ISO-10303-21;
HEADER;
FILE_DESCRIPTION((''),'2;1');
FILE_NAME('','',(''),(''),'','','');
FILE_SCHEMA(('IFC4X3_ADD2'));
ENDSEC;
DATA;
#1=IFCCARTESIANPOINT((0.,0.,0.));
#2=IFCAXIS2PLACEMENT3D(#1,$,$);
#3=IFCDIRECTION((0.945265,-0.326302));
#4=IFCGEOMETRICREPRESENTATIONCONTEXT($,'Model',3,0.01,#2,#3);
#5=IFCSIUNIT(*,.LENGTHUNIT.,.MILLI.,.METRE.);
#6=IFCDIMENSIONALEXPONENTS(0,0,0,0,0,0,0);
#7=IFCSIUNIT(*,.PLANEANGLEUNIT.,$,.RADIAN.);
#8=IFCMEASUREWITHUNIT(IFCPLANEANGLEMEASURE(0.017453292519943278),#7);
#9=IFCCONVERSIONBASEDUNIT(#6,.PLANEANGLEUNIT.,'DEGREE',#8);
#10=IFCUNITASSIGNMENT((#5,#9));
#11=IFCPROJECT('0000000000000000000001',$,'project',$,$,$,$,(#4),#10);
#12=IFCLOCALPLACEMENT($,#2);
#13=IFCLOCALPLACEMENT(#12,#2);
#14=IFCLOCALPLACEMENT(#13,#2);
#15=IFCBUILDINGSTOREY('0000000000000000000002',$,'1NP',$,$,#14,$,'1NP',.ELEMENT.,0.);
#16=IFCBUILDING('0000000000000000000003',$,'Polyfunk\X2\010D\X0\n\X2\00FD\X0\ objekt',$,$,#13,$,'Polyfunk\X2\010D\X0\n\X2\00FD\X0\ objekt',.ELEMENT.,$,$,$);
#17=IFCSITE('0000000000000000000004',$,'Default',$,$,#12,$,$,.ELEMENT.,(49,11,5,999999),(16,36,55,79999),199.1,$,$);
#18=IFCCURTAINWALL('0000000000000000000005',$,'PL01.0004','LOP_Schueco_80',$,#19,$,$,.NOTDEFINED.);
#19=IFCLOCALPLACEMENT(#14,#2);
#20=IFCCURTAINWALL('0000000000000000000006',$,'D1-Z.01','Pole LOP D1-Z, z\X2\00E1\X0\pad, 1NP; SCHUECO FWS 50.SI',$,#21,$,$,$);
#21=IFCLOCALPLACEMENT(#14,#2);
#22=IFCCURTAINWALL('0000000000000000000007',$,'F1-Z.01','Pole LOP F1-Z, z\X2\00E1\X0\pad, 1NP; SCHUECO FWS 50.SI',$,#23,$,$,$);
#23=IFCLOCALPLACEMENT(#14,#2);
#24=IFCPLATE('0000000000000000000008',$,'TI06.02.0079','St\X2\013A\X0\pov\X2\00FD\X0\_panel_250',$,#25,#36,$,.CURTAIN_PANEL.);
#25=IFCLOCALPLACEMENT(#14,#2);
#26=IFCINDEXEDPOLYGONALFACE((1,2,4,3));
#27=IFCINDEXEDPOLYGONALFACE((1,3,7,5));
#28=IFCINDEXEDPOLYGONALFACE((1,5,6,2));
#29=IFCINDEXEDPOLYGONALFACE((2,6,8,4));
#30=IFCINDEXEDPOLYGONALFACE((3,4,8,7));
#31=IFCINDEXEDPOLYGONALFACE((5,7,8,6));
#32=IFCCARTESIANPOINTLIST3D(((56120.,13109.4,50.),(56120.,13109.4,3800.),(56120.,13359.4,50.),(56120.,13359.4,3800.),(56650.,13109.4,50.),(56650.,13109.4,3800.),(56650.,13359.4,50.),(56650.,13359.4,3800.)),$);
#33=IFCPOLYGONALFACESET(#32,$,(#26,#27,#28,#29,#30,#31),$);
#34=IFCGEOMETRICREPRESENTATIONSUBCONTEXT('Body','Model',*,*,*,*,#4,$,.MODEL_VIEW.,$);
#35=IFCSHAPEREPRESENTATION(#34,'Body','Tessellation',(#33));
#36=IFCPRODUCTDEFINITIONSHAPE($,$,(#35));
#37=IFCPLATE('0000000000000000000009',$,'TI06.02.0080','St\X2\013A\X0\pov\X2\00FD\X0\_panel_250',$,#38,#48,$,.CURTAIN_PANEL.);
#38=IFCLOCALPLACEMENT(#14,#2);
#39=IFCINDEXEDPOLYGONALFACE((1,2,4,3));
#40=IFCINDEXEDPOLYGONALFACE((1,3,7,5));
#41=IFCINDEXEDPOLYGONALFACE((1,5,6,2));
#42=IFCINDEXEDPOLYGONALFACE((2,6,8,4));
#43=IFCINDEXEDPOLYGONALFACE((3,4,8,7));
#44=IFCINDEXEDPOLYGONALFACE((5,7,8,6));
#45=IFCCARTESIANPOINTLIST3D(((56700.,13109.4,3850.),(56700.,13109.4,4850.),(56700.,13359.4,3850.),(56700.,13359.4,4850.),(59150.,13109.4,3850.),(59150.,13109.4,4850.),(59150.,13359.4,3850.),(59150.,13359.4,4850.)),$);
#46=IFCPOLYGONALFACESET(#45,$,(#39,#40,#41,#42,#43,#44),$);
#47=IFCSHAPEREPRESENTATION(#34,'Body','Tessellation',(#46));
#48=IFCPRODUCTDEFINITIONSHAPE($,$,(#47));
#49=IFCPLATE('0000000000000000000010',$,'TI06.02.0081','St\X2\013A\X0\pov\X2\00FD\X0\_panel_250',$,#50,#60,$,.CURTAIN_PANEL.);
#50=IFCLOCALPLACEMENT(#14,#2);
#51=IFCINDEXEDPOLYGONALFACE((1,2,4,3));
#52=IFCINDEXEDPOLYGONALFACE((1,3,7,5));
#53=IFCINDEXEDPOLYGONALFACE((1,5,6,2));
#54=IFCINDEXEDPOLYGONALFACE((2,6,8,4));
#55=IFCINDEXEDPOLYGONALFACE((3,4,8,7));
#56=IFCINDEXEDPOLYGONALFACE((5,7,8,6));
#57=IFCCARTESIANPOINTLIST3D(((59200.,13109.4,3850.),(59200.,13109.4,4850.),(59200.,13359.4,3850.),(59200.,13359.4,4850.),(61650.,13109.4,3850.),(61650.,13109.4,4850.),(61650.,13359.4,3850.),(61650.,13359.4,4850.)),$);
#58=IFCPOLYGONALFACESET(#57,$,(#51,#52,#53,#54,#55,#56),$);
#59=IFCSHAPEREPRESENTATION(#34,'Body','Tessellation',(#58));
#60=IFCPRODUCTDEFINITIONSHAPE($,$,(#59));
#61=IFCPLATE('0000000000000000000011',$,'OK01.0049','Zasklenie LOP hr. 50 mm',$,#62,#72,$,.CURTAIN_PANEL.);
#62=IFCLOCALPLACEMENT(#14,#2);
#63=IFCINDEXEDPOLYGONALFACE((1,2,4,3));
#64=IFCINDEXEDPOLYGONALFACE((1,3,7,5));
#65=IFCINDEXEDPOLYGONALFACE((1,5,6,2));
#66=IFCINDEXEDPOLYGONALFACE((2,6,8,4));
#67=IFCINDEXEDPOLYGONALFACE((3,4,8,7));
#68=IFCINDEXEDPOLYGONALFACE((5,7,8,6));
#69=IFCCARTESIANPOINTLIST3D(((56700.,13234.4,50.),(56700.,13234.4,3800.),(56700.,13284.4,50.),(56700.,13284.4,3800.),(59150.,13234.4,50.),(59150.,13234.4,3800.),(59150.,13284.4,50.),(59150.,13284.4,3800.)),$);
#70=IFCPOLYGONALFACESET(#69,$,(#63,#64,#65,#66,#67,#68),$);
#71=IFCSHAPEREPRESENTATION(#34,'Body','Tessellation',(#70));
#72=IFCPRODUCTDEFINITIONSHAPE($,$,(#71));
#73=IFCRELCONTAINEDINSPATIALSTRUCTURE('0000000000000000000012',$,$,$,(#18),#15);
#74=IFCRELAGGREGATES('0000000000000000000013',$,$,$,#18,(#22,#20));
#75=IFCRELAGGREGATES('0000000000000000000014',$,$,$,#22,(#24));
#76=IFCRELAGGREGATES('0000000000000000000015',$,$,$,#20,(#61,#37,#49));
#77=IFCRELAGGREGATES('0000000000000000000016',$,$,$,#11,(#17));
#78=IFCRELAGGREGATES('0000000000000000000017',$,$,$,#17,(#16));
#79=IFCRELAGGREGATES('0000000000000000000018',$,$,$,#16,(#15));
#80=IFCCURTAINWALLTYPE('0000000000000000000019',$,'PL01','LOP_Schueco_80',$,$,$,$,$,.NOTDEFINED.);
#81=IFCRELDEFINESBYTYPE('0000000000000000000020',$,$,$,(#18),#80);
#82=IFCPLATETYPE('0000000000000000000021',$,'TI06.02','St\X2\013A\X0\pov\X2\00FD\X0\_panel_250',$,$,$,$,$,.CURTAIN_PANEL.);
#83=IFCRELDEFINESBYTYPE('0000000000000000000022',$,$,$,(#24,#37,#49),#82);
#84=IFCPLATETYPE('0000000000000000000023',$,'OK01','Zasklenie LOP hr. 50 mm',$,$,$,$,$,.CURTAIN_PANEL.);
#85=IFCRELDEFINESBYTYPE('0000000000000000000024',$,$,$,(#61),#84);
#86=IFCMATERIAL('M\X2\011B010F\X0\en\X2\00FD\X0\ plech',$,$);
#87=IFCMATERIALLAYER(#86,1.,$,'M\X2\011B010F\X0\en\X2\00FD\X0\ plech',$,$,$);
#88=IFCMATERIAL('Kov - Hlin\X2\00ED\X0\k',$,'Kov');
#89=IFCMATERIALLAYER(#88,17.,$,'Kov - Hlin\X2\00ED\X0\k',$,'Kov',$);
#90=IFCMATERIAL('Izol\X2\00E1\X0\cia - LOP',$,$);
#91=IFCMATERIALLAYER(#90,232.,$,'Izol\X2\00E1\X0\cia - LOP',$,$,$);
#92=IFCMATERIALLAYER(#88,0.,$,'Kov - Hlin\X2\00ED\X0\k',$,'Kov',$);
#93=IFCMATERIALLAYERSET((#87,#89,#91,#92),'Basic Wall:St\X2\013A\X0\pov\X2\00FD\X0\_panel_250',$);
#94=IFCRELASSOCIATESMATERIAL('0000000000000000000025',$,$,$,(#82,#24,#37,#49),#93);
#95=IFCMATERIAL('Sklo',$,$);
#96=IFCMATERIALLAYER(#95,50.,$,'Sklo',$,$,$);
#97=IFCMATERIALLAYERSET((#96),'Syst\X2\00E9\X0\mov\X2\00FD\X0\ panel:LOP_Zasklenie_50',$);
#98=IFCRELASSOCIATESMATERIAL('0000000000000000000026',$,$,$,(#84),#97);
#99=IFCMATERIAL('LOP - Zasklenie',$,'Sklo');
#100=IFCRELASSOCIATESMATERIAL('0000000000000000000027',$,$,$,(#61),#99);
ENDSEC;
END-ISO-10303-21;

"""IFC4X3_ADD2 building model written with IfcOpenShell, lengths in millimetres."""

from ifc_helpers import new_model, entity, si_unit, converted_unit, direction, frame, frame_2d, origin, place, context, subcontext, project, spatial, rectangle, extrude, source, transform, mapped, material, layer, layer_set, layer_usage, type_object, type_shapes, element, aggregate, save


model = new_model("IFC4X3_ADD2")

# Units and contexts
model_context = context("Model", 3, precision=0.01, world=origin(), true_north=direction((0.945265, -0.326302)))
body_context = subcontext(model_context, "Body", "Model", "MODEL_VIEW")
ifc_project = project(units=[si_unit("LENGTHUNIT", "METRE", prefix="MILLI"), converted_unit("PLANEANGLEUNIT", "DEGREE", entity("IfcPlaneAngleMeasure", 0.017453292519943278), si_unit("PLANEANGLEUNIT", "RADIAN"), dimensions=[0, 0, 0, 0, 0, 0, 0])], contexts=[model_context])

# Site, building, storey
site_placement = place(None, origin())
site = spatial("IfcSite", under=ifc_project, at=site_placement, Name="Default", CompositionType="ELEMENT", RefLatitude=(49, 11, 5, 999999), RefLongitude=(16, 36, 55, 79999), RefElevation=199.1)
building_placement = place(site_placement, origin())
building = spatial("IfcBuilding", under=site, at=building_placement, Name="Polyfunkčný objekt", LongName="Polyfunkčný objekt", CompositionType="ELEMENT")
storey_placement = place(building_placement, origin())
storey = spatial("IfcBuildingStorey", under=building, at=storey_placement, Name="1NP", LongName="1NP", CompositionType="ELEMENT", Elevation=0.0)

# Curtain walls, plates
curtain_wall_type = type_object("IfcCurtainWallType", Name="PL01", Description="LOP_Schueco_80", PredefinedType="NOTDEFINED")
curtain_wall_1_placement = place(storey_placement, origin())
curtain_wall_1 = element("IfcCurtainWall", 1, at=curtain_wall_1_placement, inside=storey, type_object=curtain_wall_type, Name="PL01.0004", Description="LOP_Schueco_80", PredefinedType="NOTDEFINED")
curtain_wall_2 = element("IfcCurtainWall", 2, Name="D1-Z.01", Description="Pole LOP D1-Z, západ, 1NP; SCHUECO FWS 50.SI")
curtain_wall_3 = element("IfcCurtainWall", 3, Name="F1-Z.01", Description="Pole LOP F1-Z, západ, 1NP; SCHUECO FWS 50.SI")
aggregate(curtain_wall_1, [curtain_wall_3, curtain_wall_2])
ifc_material_1 = material(Name="Měďený plech")
ifc_layer_1 = layer(ifc_material_1, 1.0, Name="Měďený plech")
ifc_material_2 = material(Name="Kov - Hliník", Category="Kov")
ifc_layer_2 = layer(ifc_material_2, 17.0, Name="Kov - Hliník", Category="Kov")
ifc_material_3 = material(Name="Izolácia - LOP")
ifc_layer_3 = layer(ifc_material_3, 232.0, Name="Izolácia - LOP")
ifc_layer_4 = layer(ifc_material_2, 0.0, Name="Kov - Hliník", Category="Kov")
ifc_layer_set_1 = layer_set([ifc_layer_1, ifc_layer_2, ifc_layer_3, ifc_layer_4], Name="Basic Wall:Stĺpový_panel_250")
ifc_layer_usage_1 = layer_usage(ifc_layer_set_1, "AXIS2", "NEGATIVE", 125.0)
plate_type_1 = type_object("IfcPlateType", Name="TI06.02", Description="Stĺpový_panel_250", PredefinedType="CURTAIN_PANEL", material=ifc_layer_set_1)
plate_1_placement = place(storey_placement, frame((56120.0, 13234.4, 50.0)))
plate_1 = element("IfcPlate", 4, at=plate_1_placement, type_object=plate_type_1, material=ifc_layer_usage_1, Name="TI06.02.0079", Description="Stĺpový_panel_250", PredefinedType="CURTAIN_PANEL", context=body_context, shape_type="SweptSolid", body=[
    extrude(rectangle(XDim=250.0, YDim=530.0, at=frame_2d((0.0, 0.0), x_axis=(1.0, 0.0))), frame((265.0, 0.0, 0.0), z_axis=(0.0, 0.0, 1.0), x_axis=(0.0, 1.0, 0.0)), (0.0, 0.0, 1.0), 3750.0),
])
aggregate(curtain_wall_3, [plate_1])
ifc_layer_usage_2 = layer_usage(ifc_layer_set_1, "AXIS2", "NEGATIVE", 125.0)
plate_2_placement = place(storey_placement, frame((56700.0, 13234.4, 3850.0)))
plate_2 = element("IfcPlate", 5, at=plate_2_placement, type_object=plate_type_1, material=ifc_layer_usage_2, Name="TI06.02.0080", Description="Stĺpový_panel_250", PredefinedType="CURTAIN_PANEL", context=body_context, shape_type="SweptSolid", body=[
    extrude(rectangle(XDim=250.0, YDim=2450.0, at=frame_2d((0.0, 0.0), x_axis=(1.0, 0.0))), frame((1225.0, 0.0, 0.0), z_axis=(0.0, 0.0, 1.0), x_axis=(0.0, 1.0, 0.0)), (0.0, 0.0, 1.0), 1000.0),
])
ifc_layer_usage_3 = layer_usage(ifc_layer_set_1, "AXIS2", "NEGATIVE", 125.0)
plate_3_placement = place(storey_placement, frame((59200.0, 13234.4, 3850.0)))
plate_3 = element("IfcPlate", 6, at=plate_3_placement, type_object=plate_type_1, material=ifc_layer_usage_3, Name="TI06.02.0081", Description="Stĺpový_panel_250", PredefinedType="CURTAIN_PANEL", context=body_context, shape_type="SweptSolid", body=[
    extrude(rectangle(XDim=250.0, YDim=2450.0, at=frame_2d((0.0, 0.0), x_axis=(1.0, 0.0))), frame((1225.0, 0.0, 0.0), z_axis=(0.0, 0.0, 1.0), x_axis=(0.0, 1.0, 0.0)), (0.0, 0.0, 1.0), 1000.0),
])
ifc_material_4 = material(Name="LOP - Zasklenie", Category="Sklo")
ifc_material_5 = material(Name="Sklo")
ifc_layer_5 = layer(ifc_material_5, 50.0, Name="Sklo")
ifc_layer_set_2 = layer_set([ifc_layer_5], Name="Systémový panel:LOP_Zasklenie_50")
plate_type_2 = type_object("IfcPlateType", Name="OK01", Description="Zasklenie LOP hr. 50 mm", PredefinedType="CURTAIN_PANEL", material=ifc_layer_set_2)
shared_shape_1 = source(origin(), body_context, "Body", "SweptSolid", [
    extrude(rectangle(XDim=3750.0, YDim=2450.0, at=frame_2d((-141.7, 0.0), x_axis=(1.0, 0.0))), frame((0.0, 0.0, 2016.7), z_axis=(0.0, 1.0, 0.0), x_axis=(0.0, 0.0, 1.0)), (0.0, 0.0, 1.0), 50.0),
])
type_shapes(plate_type_2, [shared_shape_1])
plate_4_placement = place(curtain_wall_1_placement, frame((57925.0, 13234.4, 50.0)))
plate_4 = element("IfcPlate", 7, at=plate_4_placement, type_object=plate_type_2, material=ifc_material_4, Name="OK01.0049", Description="Zasklenie LOP hr. 50 mm", PredefinedType="CURTAIN_PANEL", context=body_context, shape_type="MappedRepresentation", body=[
    mapped(shared_shape_1, transform((0.0, 0.0, 0.0), scale=1.0)),
])
aggregate(curtain_wall_2, [plate_4, plate_2, plate_3])

save(model, "model.ifc")
